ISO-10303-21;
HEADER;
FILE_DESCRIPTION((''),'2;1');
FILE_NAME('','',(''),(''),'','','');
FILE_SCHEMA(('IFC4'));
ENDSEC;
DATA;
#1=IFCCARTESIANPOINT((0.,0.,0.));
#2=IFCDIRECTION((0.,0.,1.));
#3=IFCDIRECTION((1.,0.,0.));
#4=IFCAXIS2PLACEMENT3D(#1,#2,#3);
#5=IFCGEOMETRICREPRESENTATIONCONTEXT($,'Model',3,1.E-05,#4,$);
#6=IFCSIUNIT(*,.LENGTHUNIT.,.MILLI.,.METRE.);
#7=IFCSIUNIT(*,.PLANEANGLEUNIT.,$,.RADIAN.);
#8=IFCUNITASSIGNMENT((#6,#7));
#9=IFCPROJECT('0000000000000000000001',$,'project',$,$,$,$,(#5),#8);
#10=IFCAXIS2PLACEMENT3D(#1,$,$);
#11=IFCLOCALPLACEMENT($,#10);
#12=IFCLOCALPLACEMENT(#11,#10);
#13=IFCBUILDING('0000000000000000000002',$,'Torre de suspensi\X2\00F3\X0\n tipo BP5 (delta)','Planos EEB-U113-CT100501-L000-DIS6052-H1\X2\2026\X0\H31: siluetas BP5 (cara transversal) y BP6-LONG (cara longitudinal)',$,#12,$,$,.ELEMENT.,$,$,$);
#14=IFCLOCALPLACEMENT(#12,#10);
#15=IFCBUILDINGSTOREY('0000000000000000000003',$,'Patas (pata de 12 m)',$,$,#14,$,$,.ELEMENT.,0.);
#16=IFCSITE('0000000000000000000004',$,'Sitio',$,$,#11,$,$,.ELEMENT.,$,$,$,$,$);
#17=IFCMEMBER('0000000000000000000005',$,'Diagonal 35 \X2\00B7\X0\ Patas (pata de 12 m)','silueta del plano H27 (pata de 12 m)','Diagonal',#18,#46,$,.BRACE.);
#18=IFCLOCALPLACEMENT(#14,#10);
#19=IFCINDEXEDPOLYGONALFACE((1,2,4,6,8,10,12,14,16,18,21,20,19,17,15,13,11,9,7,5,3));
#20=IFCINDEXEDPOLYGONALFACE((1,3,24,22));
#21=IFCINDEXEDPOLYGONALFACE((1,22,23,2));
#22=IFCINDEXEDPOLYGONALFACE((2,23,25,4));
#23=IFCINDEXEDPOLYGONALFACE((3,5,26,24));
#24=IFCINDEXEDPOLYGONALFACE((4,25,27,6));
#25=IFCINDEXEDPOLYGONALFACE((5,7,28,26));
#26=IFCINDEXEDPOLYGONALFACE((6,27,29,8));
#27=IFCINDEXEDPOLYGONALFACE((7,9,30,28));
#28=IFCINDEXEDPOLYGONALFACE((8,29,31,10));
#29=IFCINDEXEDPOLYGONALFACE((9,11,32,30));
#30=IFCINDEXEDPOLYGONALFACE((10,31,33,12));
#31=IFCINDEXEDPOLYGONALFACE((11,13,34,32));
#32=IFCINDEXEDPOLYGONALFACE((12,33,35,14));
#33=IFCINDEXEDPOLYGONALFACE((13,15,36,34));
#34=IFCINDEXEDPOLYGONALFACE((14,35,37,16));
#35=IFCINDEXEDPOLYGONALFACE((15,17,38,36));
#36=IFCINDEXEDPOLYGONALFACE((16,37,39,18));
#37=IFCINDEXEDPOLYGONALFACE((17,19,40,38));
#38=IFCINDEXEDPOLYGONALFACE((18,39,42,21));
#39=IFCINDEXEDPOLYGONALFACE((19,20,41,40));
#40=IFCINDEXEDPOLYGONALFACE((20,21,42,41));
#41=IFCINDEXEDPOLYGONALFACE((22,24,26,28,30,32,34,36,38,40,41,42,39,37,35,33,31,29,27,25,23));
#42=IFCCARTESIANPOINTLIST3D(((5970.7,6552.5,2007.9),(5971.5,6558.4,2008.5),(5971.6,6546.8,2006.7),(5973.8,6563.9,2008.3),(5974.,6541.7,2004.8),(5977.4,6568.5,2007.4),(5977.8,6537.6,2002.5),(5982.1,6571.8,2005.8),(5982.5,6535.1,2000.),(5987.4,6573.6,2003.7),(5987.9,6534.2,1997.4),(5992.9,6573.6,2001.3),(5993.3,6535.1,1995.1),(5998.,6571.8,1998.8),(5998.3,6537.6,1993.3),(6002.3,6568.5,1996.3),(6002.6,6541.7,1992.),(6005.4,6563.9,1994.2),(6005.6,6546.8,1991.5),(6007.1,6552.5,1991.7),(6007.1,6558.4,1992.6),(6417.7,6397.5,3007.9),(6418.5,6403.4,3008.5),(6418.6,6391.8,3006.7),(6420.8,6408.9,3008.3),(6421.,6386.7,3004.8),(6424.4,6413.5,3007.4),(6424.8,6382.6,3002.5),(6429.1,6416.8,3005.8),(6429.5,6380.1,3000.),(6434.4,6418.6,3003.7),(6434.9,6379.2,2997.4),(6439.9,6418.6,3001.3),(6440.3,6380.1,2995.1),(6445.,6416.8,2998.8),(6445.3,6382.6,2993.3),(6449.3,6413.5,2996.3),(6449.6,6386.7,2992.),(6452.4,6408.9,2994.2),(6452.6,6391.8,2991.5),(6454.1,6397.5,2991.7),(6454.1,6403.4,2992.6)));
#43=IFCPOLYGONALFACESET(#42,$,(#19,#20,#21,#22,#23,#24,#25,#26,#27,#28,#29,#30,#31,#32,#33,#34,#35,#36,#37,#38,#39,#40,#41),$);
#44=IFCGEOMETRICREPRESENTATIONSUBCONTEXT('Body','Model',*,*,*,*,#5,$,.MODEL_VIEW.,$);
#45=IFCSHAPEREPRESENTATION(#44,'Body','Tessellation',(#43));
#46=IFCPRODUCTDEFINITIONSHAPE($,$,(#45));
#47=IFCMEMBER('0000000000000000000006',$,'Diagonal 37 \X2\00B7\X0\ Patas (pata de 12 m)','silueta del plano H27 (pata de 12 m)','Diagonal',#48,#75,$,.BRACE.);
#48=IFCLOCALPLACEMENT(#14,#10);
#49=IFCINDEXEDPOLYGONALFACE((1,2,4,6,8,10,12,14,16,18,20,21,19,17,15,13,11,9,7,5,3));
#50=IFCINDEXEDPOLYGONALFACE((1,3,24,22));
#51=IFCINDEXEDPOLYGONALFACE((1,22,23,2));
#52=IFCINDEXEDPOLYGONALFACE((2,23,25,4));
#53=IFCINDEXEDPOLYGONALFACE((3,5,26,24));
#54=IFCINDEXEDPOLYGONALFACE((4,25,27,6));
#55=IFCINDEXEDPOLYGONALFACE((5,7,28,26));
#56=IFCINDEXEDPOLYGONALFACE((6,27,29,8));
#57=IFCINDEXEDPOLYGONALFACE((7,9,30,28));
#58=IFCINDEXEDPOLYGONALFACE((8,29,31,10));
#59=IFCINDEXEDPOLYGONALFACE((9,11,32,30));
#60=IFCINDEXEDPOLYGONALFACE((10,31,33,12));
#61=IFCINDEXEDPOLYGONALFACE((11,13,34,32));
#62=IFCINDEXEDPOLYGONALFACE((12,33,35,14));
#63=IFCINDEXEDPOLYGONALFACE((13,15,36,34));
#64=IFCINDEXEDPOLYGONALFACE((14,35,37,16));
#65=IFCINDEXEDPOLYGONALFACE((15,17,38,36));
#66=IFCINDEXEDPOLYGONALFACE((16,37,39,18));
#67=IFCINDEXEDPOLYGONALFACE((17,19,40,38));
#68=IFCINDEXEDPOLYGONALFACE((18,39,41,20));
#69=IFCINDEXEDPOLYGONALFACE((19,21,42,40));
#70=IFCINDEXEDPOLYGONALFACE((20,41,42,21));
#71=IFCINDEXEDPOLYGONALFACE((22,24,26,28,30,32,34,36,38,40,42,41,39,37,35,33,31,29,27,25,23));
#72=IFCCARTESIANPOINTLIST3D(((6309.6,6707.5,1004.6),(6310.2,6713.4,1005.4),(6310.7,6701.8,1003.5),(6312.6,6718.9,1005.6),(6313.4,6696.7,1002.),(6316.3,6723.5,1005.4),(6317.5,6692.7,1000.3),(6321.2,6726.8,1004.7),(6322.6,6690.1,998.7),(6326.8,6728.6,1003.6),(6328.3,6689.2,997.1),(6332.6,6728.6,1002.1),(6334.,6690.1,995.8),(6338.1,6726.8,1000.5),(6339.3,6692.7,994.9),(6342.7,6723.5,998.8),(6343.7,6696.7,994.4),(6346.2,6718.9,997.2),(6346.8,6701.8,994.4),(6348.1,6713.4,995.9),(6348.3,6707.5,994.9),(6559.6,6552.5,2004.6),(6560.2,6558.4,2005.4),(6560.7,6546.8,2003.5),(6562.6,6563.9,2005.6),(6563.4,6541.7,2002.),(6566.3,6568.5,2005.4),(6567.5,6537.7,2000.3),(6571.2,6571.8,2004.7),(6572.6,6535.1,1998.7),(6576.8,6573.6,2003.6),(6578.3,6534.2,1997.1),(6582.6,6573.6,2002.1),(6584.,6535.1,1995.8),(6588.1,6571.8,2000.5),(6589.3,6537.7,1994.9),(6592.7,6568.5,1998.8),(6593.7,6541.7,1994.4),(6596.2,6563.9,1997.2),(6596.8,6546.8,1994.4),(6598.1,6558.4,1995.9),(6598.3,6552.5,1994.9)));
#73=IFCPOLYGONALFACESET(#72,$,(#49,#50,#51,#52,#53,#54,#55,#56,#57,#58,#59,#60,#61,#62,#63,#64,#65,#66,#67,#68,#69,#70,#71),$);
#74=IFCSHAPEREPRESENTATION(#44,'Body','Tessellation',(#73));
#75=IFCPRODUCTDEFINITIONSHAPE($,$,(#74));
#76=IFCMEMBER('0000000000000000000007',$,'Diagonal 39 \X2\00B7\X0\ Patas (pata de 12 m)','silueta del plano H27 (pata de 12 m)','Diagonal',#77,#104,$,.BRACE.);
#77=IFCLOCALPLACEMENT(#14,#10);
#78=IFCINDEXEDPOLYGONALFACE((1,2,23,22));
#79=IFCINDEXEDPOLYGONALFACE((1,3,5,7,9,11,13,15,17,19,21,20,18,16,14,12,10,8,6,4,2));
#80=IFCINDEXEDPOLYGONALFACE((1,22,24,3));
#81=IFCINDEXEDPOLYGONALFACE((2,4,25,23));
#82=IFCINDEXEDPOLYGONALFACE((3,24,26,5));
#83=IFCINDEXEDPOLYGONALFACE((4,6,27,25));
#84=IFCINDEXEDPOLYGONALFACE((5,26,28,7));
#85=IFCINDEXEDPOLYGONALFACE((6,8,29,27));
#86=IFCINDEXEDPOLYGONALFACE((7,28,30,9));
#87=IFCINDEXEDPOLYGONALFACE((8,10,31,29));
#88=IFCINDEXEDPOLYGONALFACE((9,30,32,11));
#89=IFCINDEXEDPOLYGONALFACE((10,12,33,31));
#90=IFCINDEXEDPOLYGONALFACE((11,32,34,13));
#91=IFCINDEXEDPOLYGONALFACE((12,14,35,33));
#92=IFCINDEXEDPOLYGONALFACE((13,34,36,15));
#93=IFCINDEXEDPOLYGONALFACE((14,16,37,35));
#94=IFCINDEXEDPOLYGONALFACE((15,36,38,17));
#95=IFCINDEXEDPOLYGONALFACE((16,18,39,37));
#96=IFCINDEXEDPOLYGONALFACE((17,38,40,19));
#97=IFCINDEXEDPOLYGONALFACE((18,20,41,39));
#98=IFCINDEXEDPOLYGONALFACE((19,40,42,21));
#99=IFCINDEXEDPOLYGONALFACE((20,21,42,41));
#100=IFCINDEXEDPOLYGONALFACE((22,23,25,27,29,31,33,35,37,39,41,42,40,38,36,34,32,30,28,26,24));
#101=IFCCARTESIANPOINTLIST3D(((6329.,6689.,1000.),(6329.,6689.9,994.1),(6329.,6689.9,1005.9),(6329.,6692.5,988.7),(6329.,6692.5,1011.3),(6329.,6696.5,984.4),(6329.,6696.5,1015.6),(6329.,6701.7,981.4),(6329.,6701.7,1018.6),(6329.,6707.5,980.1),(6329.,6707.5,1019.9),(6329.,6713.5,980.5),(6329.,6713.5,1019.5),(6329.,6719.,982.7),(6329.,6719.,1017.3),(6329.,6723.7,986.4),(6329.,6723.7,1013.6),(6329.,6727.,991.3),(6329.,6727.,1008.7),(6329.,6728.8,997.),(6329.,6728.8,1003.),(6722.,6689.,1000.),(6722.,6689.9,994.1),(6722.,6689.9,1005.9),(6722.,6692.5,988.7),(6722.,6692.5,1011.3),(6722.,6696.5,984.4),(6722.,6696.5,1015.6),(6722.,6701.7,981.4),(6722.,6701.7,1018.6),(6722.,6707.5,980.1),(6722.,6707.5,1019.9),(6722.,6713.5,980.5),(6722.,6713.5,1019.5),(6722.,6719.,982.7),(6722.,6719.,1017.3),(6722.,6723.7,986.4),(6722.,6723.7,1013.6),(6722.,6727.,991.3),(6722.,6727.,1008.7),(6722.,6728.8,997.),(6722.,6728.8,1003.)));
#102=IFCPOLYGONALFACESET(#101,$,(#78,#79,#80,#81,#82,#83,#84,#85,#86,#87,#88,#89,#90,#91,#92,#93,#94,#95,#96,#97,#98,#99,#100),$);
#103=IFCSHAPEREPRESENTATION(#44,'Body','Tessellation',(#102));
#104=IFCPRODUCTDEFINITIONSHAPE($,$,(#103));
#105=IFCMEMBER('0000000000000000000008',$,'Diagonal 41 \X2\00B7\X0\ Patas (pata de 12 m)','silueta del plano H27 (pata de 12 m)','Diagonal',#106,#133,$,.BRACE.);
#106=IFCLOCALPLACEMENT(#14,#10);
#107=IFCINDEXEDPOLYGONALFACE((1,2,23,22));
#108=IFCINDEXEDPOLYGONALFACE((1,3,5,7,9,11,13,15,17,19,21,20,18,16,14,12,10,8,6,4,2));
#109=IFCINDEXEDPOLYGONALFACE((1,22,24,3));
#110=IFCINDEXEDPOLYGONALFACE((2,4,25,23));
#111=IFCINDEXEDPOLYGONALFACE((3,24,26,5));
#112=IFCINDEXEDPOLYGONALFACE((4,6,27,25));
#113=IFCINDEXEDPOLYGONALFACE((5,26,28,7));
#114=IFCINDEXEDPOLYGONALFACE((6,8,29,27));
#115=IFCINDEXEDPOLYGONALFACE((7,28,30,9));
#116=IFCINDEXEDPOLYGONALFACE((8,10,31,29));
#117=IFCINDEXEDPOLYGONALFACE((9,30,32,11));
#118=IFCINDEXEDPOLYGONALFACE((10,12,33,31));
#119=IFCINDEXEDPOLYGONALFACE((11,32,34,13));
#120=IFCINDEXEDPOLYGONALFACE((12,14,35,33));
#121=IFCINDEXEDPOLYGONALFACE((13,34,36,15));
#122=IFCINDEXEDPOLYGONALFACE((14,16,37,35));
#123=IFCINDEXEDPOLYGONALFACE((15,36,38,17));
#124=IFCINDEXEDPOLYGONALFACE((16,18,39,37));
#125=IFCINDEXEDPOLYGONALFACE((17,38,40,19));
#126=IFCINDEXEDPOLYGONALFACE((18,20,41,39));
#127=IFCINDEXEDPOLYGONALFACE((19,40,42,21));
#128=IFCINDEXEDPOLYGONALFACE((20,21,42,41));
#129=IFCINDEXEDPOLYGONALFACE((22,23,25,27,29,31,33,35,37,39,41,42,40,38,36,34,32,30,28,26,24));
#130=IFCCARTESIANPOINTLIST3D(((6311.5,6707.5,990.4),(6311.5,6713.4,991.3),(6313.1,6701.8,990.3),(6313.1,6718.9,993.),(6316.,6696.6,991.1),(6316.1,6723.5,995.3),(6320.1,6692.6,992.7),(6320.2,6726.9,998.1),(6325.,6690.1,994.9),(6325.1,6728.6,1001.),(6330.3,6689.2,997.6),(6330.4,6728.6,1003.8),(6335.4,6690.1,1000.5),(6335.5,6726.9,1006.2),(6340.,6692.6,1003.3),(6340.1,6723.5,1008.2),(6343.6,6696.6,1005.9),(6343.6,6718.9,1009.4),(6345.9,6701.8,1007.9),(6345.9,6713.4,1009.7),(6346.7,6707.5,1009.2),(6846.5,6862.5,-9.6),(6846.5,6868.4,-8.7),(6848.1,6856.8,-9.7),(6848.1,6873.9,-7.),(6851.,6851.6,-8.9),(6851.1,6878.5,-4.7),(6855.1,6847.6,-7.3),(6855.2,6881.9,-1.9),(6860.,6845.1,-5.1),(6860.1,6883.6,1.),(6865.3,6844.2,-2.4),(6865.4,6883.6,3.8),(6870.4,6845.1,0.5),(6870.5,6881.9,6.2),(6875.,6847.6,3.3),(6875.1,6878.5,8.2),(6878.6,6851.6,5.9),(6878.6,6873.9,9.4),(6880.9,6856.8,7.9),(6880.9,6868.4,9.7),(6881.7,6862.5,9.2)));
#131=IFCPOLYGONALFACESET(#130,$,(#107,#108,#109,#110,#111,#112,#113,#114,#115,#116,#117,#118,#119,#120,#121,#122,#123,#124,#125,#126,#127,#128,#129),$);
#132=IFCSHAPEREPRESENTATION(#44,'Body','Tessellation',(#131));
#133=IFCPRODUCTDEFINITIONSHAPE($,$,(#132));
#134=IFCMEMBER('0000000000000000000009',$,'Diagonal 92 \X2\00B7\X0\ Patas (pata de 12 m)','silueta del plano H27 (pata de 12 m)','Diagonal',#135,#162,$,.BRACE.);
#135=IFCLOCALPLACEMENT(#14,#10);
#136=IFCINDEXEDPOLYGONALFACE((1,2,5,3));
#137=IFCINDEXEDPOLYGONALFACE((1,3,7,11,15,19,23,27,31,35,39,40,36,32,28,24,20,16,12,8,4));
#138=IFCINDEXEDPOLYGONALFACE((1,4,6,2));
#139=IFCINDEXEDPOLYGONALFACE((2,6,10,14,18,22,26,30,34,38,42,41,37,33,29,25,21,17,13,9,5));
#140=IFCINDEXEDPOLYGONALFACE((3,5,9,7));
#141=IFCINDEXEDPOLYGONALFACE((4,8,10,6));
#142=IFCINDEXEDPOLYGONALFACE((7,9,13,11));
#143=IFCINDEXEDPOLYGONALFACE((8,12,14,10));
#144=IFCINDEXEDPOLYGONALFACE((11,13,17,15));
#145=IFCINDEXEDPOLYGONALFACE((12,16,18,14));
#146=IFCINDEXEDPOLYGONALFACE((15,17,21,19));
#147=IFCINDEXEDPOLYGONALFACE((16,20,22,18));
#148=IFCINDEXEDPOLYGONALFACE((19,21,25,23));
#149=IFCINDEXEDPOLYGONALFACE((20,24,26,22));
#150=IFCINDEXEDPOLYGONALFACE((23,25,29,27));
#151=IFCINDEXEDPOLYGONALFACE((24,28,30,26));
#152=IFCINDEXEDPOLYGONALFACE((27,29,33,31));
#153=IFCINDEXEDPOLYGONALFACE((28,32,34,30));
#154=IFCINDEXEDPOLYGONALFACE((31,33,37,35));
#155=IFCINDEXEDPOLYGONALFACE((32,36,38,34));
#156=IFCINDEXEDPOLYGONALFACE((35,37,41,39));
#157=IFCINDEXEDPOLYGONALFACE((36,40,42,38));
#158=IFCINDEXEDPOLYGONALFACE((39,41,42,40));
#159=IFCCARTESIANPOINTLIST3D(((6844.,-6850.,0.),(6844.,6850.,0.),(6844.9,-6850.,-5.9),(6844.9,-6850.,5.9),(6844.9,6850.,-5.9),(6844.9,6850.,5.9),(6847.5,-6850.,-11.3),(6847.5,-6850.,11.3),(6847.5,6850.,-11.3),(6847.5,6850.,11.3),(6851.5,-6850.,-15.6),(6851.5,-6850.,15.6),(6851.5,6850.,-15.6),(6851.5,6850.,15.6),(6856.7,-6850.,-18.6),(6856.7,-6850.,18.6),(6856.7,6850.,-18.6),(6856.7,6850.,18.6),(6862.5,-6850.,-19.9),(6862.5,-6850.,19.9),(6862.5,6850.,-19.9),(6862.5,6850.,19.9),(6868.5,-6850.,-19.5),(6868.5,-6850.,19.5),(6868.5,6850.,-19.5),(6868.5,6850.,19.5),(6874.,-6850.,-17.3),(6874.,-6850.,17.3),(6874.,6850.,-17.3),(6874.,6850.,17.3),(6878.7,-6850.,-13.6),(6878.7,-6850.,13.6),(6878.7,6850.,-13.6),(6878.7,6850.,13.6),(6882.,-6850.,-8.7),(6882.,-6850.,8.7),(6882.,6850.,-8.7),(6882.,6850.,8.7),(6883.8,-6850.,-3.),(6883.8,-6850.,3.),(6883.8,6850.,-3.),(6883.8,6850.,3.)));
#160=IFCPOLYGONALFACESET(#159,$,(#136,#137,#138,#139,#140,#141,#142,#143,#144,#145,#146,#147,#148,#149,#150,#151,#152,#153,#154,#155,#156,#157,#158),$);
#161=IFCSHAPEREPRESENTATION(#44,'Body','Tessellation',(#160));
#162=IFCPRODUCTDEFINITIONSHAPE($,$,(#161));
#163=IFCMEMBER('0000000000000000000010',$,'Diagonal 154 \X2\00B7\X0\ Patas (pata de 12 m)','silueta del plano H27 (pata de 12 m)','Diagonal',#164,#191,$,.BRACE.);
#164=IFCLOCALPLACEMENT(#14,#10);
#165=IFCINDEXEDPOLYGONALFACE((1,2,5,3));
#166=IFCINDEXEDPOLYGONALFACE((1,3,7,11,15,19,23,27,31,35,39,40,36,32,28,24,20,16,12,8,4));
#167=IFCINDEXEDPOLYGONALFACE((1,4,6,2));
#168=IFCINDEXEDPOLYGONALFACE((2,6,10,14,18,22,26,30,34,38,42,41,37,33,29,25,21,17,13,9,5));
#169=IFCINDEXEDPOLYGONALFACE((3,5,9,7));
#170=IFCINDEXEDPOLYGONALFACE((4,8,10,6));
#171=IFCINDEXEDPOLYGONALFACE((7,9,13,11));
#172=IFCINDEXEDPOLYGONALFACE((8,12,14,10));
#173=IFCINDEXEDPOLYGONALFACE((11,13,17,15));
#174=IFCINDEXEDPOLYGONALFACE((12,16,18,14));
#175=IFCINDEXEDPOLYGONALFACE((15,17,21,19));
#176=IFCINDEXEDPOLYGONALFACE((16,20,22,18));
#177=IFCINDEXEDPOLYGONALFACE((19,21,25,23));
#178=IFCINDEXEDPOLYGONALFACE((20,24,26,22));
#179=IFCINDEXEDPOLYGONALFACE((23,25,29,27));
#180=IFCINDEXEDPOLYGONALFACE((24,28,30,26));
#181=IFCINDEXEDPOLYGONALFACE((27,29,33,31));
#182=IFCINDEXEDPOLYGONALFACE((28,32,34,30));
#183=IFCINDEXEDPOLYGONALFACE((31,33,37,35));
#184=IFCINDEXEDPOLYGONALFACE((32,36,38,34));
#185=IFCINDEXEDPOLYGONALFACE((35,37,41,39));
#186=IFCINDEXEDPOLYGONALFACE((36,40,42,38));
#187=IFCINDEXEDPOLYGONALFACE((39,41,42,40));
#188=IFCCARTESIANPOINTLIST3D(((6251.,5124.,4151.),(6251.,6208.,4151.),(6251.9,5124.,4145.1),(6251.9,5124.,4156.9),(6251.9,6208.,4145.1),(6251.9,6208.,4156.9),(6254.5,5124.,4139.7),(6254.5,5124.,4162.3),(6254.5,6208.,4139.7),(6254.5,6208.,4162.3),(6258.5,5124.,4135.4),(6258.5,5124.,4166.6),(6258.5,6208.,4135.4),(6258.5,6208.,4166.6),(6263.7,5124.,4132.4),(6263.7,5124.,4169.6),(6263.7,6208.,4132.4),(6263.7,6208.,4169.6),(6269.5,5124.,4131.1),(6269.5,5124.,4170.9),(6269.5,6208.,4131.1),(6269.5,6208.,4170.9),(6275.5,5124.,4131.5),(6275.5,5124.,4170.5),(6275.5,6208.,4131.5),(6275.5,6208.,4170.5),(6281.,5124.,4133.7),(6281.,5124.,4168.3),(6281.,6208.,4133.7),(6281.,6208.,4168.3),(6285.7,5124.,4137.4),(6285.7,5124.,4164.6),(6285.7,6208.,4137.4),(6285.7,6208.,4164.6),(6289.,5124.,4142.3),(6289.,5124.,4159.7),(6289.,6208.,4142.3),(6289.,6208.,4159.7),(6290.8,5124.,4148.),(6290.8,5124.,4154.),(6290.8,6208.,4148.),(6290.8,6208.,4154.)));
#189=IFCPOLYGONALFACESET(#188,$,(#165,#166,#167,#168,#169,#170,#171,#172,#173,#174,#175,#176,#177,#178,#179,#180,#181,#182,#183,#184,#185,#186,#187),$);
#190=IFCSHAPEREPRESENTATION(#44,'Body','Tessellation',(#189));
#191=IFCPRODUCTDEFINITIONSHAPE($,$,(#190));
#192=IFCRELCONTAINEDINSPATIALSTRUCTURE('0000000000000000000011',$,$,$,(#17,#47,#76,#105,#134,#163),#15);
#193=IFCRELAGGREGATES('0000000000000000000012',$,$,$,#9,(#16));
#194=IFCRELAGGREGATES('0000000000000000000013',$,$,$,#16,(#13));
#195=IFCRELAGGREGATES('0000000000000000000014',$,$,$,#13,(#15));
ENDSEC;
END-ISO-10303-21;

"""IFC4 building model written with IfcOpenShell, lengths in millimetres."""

from ifc_helpers import new_model, si_unit, frame, origin, origin_with_axes, place, context, subcontext, project, spatial, circle, extrude, element, save


model = new_model("IFC4")

# Units and contexts
model_context = context("Model", 3, precision=1e-05, world=origin_with_axes())
body_context = subcontext(model_context, "Body", "Model", "MODEL_VIEW")
ifc_project = project(units=[si_unit("LENGTHUNIT", "METRE", prefix="MILLI"), si_unit("PLANEANGLEUNIT", "RADIAN")], contexts=[model_context])

# Site, building, storey
site_placement = place(None, origin())
site = spatial("IfcSite", under=ifc_project, at=site_placement, Name="Sitio", CompositionType="ELEMENT")
building_placement = place(site_placement, origin())
building = spatial("IfcBuilding", under=site, at=building_placement, Name="Torre de suspensión tipo BP5 (delta)", Description="Planos EEB-U113-CT100501-L000-DIS6052-H1…H31: siluetas BP5 (cara transversal) y BP6-LONG (cara longitudinal)", CompositionType="ELEMENT")
storey_placement = place(building_placement, origin())
storey = spatial("IfcBuildingStorey", under=building, at=storey_placement, Name="Patas (pata de 12 m)", CompositionType="ELEMENT", Elevation=0.0)

# Members
member_1_placement = place(storey_placement, frame((5989.0, 6554.0, 2000.0), z_axis=(0.40406, -0.14011, 0.903938), x_axis=(-0.057177, -0.990136, -0.127913)))
element("IfcMember", 1, at=member_1_placement, inside=storey, Name="Diagonal 35 · Patas (pata de 12 m)", Description="silueta del plano H27 (pata de 12 m)", ObjectType="Diagonal", PredefinedType="BRACE", context=body_context, shape_type="SweptSolid", body=[
    extrude(circle(Radius=20.0), None, (0.0, 0.0, 1.0), 1106.3),
])
member_2_placement = place(storey_placement, frame((6329.0, 6709.0, 1000.0), z_axis=(0.239839, -0.1487, 0.959357), x_axis=(-0.036065, -0.988882, -0.14426)))
element("IfcMember", 2, at=member_2_placement, inside=storey, Name="Diagonal 37 · Patas (pata de 12 m)", Description="silueta del plano H27 (pata de 12 m)", ObjectType="Diagonal", PredefinedType="BRACE", context=body_context, shape_type="SweptSolid", body=[
    extrude(circle(Radius=20.0), None, (0.0, 0.0, 1.0), 1042.4),
])
member_3_placement = place(storey_placement, frame((6722.0, 6709.0, 1000.0), z_axis=(-1.0, 0.0, 0.0), x_axis=(0.0, -1.0, 0.0)))
element("IfcMember", 3, at=member_3_placement, inside=storey, Name="Diagonal 39 · Patas (pata de 12 m)", Description="silueta del plano H27 (pata de 12 m)", ObjectType="Diagonal", PredefinedType="BRACE", context=body_context, shape_type="SweptSolid", body=[
    extrude(circle(Radius=20.0), None, (0.0, 0.0, 1.0), 393.0),
])
member_4_placement = place(storey_placement, frame((6864.0, 6864.0, 0.0), z_axis=(-0.467387, -0.135411, 0.873621), x_axis=(0.063878, -0.990789, -0.119398)))
element("IfcMember", 4, at=member_4_placement, inside=storey, Name="Diagonal 41 · Patas (pata de 12 m)", Description="silueta del plano H27 (pata de 12 m)", ObjectType="Diagonal", PredefinedType="BRACE", context=body_context, shape_type="SweptSolid", body=[
    extrude(circle(Radius=20.0), None, (0.0, 0.0, 1.0), 1144.7),
])
member_5_placement = place(storey_placement, frame((6864.0, 6850.0, 0.0), z_axis=(0.0, -1.0, 0.0), x_axis=(-1.0, 0.0, 0.0)))
element("IfcMember", 5, at=member_5_placement, inside=storey, Name="Diagonal 92 · Patas (pata de 12 m)", Description="silueta del plano H27 (pata de 12 m)", ObjectType="Diagonal", PredefinedType="BRACE", context=body_context, shape_type="SweptSolid", body=[
    extrude(circle(Radius=20.0), None, (0.0, 0.0, 1.0), 13700.0),
])
member_6_placement = place(storey_placement, frame((6271.0, 6208.0, 4151.0), z_axis=(0.0, -1.0, 0.0), x_axis=(-1.0, 0.0, 0.0)))
element("IfcMember", 6, at=member_6_placement, inside=storey, Name="Diagonal 154 · Patas (pata de 12 m)", Description="silueta del plano H27 (pata de 12 m)", ObjectType="Diagonal", PredefinedType="BRACE", context=body_context, shape_type="SweptSolid", body=[
    extrude(circle(Radius=20.0), None, (0.0, 0.0, 1.0), 1084.0),
])

save(model, "model.ifc")
